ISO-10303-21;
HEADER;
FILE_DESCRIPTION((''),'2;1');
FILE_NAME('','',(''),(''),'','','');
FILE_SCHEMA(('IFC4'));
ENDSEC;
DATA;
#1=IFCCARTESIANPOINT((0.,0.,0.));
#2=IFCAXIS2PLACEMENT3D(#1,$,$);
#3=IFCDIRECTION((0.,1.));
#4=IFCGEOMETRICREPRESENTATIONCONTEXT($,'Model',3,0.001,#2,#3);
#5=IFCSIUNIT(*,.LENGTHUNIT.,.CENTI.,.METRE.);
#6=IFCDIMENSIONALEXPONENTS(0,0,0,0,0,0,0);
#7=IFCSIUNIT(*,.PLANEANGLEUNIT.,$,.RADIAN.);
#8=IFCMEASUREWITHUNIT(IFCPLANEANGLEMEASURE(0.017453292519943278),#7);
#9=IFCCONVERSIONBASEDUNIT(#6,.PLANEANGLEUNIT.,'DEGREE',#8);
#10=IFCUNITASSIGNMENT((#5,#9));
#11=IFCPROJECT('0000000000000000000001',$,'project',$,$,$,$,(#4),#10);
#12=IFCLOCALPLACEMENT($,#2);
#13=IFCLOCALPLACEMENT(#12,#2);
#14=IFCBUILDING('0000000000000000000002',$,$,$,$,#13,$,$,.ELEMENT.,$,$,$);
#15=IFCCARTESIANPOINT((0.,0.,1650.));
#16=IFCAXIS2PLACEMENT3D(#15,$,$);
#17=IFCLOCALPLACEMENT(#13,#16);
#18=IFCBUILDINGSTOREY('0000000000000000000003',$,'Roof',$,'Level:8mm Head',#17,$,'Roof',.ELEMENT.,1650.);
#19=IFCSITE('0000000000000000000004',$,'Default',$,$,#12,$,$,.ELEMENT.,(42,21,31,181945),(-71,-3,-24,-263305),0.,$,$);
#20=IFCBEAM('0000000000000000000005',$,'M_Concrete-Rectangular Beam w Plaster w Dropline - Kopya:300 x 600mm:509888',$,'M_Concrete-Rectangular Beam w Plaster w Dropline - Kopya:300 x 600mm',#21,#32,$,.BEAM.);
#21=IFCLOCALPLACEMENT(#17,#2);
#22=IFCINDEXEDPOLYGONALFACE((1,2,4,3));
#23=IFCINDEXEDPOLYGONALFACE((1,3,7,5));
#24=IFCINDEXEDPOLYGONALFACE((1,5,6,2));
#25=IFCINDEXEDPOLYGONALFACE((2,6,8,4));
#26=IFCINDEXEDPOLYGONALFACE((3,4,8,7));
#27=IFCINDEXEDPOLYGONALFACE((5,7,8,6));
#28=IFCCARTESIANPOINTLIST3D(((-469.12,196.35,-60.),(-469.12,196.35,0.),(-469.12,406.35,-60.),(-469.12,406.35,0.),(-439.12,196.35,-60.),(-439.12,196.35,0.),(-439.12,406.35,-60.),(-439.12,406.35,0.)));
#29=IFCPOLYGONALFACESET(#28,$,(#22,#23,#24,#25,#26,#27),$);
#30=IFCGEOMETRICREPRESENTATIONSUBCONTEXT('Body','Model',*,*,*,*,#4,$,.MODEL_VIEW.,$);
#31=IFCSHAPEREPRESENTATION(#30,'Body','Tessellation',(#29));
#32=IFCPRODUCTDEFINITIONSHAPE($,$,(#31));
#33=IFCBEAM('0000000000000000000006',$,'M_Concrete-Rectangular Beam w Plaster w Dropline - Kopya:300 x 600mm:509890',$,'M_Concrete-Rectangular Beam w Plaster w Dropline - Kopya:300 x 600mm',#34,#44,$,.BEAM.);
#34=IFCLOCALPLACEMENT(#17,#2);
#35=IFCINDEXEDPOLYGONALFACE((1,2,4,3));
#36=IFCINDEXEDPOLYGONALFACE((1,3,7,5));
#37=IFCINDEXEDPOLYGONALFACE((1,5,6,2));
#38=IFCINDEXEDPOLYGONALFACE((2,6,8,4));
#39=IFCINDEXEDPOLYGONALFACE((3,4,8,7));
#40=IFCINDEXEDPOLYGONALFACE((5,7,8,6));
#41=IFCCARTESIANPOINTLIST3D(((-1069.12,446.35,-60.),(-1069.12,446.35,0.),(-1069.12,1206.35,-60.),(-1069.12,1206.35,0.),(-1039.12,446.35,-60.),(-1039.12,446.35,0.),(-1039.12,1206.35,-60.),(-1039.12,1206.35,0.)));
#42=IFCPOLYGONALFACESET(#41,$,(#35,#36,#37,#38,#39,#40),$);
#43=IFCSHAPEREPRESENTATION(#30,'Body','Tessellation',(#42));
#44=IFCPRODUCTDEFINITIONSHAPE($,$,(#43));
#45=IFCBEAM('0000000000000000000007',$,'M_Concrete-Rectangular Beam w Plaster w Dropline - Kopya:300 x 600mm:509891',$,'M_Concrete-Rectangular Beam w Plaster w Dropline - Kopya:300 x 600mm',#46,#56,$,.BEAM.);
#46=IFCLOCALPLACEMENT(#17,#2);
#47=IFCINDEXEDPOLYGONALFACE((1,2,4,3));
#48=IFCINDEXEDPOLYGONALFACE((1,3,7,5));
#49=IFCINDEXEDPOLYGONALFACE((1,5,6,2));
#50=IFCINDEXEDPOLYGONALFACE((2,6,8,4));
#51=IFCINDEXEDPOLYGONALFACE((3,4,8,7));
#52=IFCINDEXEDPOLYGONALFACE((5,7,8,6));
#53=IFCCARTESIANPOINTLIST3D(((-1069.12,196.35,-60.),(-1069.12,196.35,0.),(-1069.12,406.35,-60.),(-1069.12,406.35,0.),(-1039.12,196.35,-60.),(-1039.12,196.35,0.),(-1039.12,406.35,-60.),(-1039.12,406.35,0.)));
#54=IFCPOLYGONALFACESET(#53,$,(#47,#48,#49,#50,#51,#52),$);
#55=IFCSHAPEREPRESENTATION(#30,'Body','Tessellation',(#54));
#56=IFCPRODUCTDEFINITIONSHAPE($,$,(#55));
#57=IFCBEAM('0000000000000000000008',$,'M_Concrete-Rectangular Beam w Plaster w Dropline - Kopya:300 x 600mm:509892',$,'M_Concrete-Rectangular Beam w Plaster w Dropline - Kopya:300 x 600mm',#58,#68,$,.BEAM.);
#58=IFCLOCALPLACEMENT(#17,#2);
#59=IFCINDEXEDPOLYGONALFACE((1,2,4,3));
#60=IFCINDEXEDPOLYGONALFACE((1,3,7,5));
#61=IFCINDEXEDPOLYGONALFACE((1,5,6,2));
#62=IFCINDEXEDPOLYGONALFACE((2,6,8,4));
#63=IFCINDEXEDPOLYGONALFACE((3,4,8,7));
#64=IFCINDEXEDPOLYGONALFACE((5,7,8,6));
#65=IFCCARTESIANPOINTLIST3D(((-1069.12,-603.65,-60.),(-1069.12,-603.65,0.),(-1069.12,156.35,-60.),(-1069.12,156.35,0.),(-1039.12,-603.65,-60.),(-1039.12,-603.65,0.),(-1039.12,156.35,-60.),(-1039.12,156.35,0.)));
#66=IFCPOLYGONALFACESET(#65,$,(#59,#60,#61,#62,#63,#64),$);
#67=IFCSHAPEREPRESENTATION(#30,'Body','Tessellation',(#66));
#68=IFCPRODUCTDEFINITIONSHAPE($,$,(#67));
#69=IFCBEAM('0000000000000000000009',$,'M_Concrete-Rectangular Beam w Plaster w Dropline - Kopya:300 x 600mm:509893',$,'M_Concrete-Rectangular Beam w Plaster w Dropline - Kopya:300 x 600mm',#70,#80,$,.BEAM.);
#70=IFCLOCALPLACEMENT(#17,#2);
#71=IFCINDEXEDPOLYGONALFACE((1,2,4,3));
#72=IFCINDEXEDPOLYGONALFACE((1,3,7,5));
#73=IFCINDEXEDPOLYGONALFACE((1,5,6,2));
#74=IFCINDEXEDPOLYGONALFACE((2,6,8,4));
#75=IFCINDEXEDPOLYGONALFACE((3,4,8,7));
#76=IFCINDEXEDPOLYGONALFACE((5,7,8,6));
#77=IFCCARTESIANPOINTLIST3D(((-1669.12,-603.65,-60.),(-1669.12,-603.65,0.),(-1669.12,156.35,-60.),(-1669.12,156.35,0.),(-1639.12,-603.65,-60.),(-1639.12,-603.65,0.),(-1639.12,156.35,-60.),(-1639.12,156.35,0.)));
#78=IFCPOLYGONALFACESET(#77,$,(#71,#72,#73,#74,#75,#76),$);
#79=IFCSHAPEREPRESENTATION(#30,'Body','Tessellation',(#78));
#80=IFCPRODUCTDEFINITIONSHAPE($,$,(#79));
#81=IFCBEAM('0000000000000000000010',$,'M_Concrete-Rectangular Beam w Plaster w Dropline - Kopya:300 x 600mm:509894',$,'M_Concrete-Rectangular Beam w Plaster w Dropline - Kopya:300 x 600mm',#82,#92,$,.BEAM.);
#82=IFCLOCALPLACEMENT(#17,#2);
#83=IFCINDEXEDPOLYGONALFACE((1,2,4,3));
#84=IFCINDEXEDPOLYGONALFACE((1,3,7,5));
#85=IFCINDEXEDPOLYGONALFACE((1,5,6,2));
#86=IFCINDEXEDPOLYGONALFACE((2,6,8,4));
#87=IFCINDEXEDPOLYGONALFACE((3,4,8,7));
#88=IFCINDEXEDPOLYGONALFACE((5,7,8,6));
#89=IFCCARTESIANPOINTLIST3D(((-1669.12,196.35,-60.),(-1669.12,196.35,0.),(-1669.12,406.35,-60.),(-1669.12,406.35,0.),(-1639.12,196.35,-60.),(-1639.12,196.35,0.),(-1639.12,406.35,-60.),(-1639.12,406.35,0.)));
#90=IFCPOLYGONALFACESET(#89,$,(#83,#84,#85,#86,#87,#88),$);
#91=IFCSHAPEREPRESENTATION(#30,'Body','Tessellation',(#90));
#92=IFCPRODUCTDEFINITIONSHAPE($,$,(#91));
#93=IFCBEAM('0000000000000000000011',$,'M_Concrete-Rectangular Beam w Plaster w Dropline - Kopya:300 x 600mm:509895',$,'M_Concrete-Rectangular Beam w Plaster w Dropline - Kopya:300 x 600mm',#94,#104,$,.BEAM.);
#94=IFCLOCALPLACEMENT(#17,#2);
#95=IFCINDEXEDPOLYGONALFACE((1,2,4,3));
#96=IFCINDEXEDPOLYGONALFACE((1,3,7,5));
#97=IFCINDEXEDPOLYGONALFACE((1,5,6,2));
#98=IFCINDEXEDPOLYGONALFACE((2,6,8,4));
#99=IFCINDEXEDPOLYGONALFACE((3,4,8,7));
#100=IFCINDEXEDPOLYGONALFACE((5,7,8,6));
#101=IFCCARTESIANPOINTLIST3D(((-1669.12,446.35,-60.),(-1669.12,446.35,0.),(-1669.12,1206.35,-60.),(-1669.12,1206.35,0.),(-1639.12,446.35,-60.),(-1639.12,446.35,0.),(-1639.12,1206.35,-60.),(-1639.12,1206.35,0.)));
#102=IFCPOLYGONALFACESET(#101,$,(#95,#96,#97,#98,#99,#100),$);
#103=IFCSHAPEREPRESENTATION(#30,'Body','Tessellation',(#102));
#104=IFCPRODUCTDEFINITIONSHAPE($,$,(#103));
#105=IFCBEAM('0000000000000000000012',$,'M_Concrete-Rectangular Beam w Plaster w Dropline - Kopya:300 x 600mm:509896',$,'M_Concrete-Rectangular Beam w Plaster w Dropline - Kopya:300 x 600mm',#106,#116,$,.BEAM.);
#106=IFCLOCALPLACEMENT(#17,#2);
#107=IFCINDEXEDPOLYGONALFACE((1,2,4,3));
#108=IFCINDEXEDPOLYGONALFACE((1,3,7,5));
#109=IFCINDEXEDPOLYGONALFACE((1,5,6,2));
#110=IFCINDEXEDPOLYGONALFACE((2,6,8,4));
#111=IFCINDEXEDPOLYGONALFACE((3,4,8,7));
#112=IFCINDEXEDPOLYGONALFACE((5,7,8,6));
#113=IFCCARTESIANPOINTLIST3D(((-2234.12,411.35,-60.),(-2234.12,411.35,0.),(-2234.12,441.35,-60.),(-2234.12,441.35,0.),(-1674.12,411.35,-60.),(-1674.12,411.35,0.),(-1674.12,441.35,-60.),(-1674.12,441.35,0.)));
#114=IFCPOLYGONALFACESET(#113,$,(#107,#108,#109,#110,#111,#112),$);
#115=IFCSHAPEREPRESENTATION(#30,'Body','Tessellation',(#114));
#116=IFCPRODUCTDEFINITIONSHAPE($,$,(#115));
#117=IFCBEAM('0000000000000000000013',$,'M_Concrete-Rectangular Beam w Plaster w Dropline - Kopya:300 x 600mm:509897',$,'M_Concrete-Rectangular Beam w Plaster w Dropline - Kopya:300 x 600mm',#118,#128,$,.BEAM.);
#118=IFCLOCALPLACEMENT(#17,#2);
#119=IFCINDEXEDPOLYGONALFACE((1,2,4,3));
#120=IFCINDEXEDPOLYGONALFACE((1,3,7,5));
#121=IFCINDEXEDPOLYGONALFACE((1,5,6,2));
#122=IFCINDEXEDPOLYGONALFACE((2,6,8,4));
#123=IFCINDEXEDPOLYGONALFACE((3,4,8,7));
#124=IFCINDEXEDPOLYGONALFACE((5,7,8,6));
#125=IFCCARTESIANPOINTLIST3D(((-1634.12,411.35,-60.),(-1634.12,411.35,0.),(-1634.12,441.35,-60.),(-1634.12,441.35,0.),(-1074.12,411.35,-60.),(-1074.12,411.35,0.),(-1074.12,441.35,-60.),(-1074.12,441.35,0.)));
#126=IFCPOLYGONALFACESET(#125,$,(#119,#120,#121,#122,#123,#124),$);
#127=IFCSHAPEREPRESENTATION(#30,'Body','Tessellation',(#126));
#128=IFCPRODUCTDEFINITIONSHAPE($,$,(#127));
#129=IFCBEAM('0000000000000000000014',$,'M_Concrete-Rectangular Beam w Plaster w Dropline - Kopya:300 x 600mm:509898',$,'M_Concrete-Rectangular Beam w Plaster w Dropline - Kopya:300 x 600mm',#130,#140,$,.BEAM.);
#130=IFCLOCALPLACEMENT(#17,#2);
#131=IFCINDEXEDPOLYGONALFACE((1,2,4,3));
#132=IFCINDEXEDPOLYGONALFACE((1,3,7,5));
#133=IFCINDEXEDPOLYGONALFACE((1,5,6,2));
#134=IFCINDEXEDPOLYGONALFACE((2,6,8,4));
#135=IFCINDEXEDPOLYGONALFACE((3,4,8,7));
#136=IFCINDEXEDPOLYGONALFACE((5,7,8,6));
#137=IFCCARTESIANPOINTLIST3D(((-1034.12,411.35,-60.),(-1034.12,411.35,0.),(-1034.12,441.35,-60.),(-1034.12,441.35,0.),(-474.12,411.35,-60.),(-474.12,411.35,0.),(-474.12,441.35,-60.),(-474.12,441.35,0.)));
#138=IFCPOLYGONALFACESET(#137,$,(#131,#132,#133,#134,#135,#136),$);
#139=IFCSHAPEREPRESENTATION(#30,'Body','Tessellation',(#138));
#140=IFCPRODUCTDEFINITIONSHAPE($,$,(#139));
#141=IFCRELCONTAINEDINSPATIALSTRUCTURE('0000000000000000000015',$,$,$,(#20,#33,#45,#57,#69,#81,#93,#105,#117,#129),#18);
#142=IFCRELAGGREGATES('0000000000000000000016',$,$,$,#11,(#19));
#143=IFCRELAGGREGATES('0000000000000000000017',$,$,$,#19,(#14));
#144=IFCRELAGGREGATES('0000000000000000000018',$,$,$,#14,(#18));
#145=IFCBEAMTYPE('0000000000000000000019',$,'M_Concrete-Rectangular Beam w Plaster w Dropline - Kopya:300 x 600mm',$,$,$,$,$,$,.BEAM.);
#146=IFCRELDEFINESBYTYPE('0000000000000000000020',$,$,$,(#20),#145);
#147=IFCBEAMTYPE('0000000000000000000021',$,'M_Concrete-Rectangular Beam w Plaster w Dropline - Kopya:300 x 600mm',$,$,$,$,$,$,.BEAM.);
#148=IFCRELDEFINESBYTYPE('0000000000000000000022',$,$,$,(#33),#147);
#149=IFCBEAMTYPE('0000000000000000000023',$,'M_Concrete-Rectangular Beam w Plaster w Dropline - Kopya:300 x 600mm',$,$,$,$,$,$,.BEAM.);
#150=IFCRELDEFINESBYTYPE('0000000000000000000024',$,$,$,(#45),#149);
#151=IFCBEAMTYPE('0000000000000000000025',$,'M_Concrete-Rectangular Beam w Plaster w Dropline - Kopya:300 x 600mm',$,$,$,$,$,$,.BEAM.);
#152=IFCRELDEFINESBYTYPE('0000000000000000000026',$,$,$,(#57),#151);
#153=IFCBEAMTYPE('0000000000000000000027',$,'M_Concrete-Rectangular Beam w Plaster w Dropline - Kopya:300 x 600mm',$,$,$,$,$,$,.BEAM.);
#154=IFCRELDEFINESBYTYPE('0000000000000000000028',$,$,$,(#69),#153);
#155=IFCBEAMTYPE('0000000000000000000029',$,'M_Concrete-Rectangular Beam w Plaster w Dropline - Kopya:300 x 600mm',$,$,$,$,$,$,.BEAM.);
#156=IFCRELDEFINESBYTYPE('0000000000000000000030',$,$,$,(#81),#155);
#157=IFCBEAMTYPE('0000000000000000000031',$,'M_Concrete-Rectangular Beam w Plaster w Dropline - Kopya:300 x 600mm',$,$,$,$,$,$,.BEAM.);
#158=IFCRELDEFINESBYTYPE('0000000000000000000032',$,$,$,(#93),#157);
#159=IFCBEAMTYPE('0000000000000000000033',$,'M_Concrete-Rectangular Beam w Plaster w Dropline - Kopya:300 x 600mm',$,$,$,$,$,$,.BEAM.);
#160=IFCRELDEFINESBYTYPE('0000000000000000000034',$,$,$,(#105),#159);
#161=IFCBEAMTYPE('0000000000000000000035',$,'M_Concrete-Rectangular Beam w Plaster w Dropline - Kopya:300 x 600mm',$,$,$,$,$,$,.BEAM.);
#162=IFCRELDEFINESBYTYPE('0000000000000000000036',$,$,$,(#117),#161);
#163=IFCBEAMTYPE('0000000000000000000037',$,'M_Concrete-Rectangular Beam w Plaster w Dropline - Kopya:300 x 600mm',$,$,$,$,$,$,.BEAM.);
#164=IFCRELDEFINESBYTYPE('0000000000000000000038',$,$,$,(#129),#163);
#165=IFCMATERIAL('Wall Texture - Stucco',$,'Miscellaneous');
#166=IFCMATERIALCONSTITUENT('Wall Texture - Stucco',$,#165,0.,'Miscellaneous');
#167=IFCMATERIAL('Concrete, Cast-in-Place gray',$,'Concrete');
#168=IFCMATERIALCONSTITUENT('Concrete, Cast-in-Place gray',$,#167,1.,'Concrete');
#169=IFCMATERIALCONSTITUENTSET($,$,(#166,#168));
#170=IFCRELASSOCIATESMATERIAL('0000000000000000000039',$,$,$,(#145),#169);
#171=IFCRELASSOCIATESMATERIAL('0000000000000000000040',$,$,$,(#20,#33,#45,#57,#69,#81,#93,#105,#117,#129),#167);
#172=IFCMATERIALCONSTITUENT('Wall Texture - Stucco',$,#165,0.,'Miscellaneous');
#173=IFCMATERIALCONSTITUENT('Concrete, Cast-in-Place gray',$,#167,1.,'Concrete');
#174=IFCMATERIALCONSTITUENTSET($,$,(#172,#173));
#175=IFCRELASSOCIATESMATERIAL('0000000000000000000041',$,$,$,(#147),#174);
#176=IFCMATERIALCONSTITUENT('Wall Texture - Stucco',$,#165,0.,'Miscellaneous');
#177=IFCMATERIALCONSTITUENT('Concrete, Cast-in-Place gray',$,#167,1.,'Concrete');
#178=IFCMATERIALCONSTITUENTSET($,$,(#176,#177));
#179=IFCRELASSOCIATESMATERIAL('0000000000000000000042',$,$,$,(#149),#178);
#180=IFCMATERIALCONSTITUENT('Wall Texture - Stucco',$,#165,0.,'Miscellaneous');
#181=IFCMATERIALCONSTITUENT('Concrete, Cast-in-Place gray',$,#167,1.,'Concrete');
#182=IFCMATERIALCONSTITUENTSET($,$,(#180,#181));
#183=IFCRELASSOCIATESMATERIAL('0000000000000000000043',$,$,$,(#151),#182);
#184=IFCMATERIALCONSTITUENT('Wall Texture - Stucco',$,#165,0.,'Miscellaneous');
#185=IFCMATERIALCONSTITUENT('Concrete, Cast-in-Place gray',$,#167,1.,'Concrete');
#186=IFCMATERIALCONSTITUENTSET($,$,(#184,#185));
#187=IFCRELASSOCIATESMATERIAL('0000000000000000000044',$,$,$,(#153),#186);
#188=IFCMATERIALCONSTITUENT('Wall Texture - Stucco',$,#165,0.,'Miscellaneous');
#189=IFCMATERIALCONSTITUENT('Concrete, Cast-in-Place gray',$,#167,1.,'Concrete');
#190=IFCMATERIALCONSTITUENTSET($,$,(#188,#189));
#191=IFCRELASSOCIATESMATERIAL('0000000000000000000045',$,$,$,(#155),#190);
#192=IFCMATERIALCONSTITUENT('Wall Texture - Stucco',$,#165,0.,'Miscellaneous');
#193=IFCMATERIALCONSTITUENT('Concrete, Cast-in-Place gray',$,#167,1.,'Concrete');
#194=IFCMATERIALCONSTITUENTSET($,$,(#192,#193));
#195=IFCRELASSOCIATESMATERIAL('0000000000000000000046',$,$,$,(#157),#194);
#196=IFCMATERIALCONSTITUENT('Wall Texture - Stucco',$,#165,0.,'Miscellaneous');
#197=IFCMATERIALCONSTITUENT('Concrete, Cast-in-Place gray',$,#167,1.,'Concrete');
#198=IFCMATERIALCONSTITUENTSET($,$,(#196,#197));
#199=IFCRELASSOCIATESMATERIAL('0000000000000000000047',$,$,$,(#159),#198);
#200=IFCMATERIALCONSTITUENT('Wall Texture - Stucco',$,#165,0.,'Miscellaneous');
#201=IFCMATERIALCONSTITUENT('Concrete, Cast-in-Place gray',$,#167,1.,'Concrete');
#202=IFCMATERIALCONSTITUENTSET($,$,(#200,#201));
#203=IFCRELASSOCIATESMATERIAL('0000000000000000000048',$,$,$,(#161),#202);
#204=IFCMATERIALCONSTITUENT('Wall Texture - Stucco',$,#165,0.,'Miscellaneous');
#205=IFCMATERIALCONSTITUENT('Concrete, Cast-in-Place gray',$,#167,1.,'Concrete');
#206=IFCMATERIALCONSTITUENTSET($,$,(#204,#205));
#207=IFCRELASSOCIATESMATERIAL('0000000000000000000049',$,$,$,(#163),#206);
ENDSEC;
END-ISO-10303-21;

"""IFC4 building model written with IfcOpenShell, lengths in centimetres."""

from ifc_helpers import new_model, entity, si_unit, converted_unit, direction, frame, origin, place, context, subcontext, project, spatial, indexed_curve, outline, extrude, source, transform, mapped, material, constituent, constituent_set, type_object, type_shapes, element, save


model = new_model("IFC4")

# Units and contexts
model_context = context("Model", 3, precision=0.001, world=origin(), true_north=direction((0.0, 1.0)))
body_context = subcontext(model_context, "Body", "Model", "MODEL_VIEW")
ifc_project = project(units=[si_unit("LENGTHUNIT", "METRE", prefix="CENTI"), converted_unit("PLANEANGLEUNIT", "DEGREE", entity("IfcPlaneAngleMeasure", 0.017453292519943278), si_unit("PLANEANGLEUNIT", "RADIAN"), dimensions=[0, 0, 0, 0, 0, 0, 0])], contexts=[model_context])

# Site, building, storey
site_placement = place(None, origin())
site = spatial("IfcSite", under=ifc_project, at=site_placement, Name="Default", CompositionType="ELEMENT", RefLatitude=(42, 21, 31, 181945), RefLongitude=(-71, -3, -24, -263305), RefElevation=0.0)
building_placement = place(site_placement, origin())
building = spatial("IfcBuilding", under=site, at=building_placement, CompositionType="ELEMENT")
storey_placement = place(building_placement, frame((0.0, 0.0, 1650.0)))
storey = spatial("IfcBuildingStorey", under=building, at=storey_placement, Name="Roof", ObjectType="Level:8mm Head", LongName="Roof", CompositionType="ELEMENT", Elevation=1650.0)

# Beams
ifc_material_1 = material(Name="Concrete, Cast-in-Place gray", Category="Concrete")
ifc_material_2 = material(Name="Wall Texture - Stucco", Category="Miscellaneous")
ifc_constituent_1 = constituent(ifc_material_2, Name="Wall Texture - Stucco", Category="Miscellaneous", fraction=0.0)
ifc_constituent_2 = constituent(ifc_material_1, Name="Concrete, Cast-in-Place gray", Category="Concrete", fraction=1.0)
ifc_constituent_set_1 = constituent_set(constituents=[ifc_constituent_1, ifc_constituent_2])
beam_type_1 = type_object("IfcBeamType", Name="M_Concrete-Rectangular Beam w Plaster w Dropline - Kopya:300 x 600mm", PredefinedType="BEAM", material=ifc_constituent_set_1)
shared_shape_1 = source(origin(), body_context, "Body", "SweptSolid", [
    extrude(outline(indexed_curve([(-15.0, -30.0), (15.0, -30.0), (15.0, 30.0), (-15.0, 30.0), (-15.0, -30.0)], self_intersect=False)), frame((-454.12, 196.35, 1620.0), z_axis=(0.0, 1.0, 0.0), x_axis=(-1.0, 0.0, 0.0)), (0.0, 0.0, 1.0), 210.0),
])
type_shapes(beam_type_1, [shared_shape_1])
beam_1_placement = place(storey_placement, frame((0.0, 0.0, -1650.0)))
element("IfcBeam", 1, at=beam_1_placement, inside=storey, type_object=beam_type_1, material=ifc_material_1, Name="M_Concrete-Rectangular Beam w Plaster w Dropline - Kopya:300 x 600mm:509888", ObjectType="M_Concrete-Rectangular Beam w Plaster w Dropline - Kopya:300 x 600mm", PredefinedType="BEAM", context=body_context, shape_type="MappedRepresentation", body=[
    mapped(shared_shape_1, transform((0.0, 0.0, 0.0), scale=1.0)),
])
ifc_constituent_3 = constituent(ifc_material_2, Name="Wall Texture - Stucco", Category="Miscellaneous", fraction=0.0)
ifc_constituent_4 = constituent(ifc_material_1, Name="Concrete, Cast-in-Place gray", Category="Concrete", fraction=1.0)
ifc_constituent_set_2 = constituent_set(constituents=[ifc_constituent_3, ifc_constituent_4])
beam_type_2 = type_object("IfcBeamType", Name="M_Concrete-Rectangular Beam w Plaster w Dropline - Kopya:300 x 600mm", PredefinedType="BEAM", material=ifc_constituent_set_2)
shared_shape_2 = source(origin(), body_context, "Body", "SweptSolid", [
    extrude(outline(indexed_curve([(-15.0, -30.0), (15.0, -30.0), (15.0, 30.0), (-15.0, 30.0), (-15.0, -30.0)], self_intersect=False)), frame((-1054.12, 1206.35, 1620.0), z_axis=(0.0, -1.0, 0.0), x_axis=(-1.0, 0.0, 0.0)), (0.0, 0.0, 1.0), 760.0),
])
type_shapes(beam_type_2, [shared_shape_2])
beam_2_placement = place(storey_placement, frame((0.0, 0.0, -1650.0)))
element("IfcBeam", 2, at=beam_2_placement, inside=storey, type_object=beam_type_2, material=ifc_material_1, Name="M_Concrete-Rectangular Beam w Plaster w Dropline - Kopya:300 x 600mm:509890", ObjectType="M_Concrete-Rectangular Beam w Plaster w Dropline - Kopya:300 x 600mm", PredefinedType="BEAM", context=body_context, shape_type="MappedRepresentation", body=[
    mapped(shared_shape_2, transform((0.0, 0.0, 0.0), scale=1.0)),
])
ifc_constituent_5 = constituent(ifc_material_2, Name="Wall Texture - Stucco", Category="Miscellaneous", fraction=0.0)
ifc_constituent_6 = constituent(ifc_material_1, Name="Concrete, Cast-in-Place gray", Category="Concrete", fraction=1.0)
ifc_constituent_set_3 = constituent_set(constituents=[ifc_constituent_5, ifc_constituent_6])
beam_type_3 = type_object("IfcBeamType", Name="M_Concrete-Rectangular Beam w Plaster w Dropline - Kopya:300 x 600mm", PredefinedType="BEAM", material=ifc_constituent_set_3)
shared_shape_3 = source(origin(), body_context, "Body", "SweptSolid", [
    extrude(outline(indexed_curve([(-15.0, -30.0), (15.0, -30.0), (15.0, 30.0), (-15.0, 30.0), (-15.0, -30.0)], self_intersect=False)), frame((-1054.12, 406.35, 1620.0), z_axis=(0.0, -1.0, 0.0), x_axis=(-1.0, 0.0, 0.0)), (0.0, 0.0, 1.0), 210.0),
])
type_shapes(beam_type_3, [shared_shape_3])
beam_3_placement = place(storey_placement, frame((0.0, 0.0, -1650.0)))
element("IfcBeam", 3, at=beam_3_placement, inside=storey, type_object=beam_type_3, material=ifc_material_1, Name="M_Concrete-Rectangular Beam w Plaster w Dropline - Kopya:300 x 600mm:509891", ObjectType="M_Concrete-Rectangular Beam w Plaster w Dropline - Kopya:300 x 600mm", PredefinedType="BEAM", context=body_context, shape_type="MappedRepresentation", body=[
    mapped(shared_shape_3, transform((0.0, 0.0, 0.0), scale=1.0)),
])
ifc_constituent_7 = constituent(ifc_material_2, Name="Wall Texture - Stucco", Category="Miscellaneous", fraction=0.0)
ifc_constituent_8 = constituent(ifc_material_1, Name="Concrete, Cast-in-Place gray", Category="Concrete", fraction=1.0)
ifc_constituent_set_4 = constituent_set(constituents=[ifc_constituent_7, ifc_constituent_8])
beam_type_4 = type_object("IfcBeamType", Name="M_Concrete-Rectangular Beam w Plaster w Dropline - Kopya:300 x 600mm", PredefinedType="BEAM", material=ifc_constituent_set_4)
shared_shape_4 = source(origin(), body_context, "Body", "SweptSolid", [
    extrude(outline(indexed_curve([(-15.0, -30.0), (15.0, -30.0), (15.0, 30.0), (-15.0, 30.0), (-15.0, -30.0)], self_intersect=False)), frame((-1054.12, 156.35, 1620.0), z_axis=(0.0, -1.0, 0.0), x_axis=(-1.0, 0.0, 0.0)), (0.0, 0.0, 1.0), 760.0),
])
type_shapes(beam_type_4, [shared_shape_4])
beam_4_placement = place(storey_placement, frame((0.0, 0.0, -1650.0)))
element("IfcBeam", 4, at=beam_4_placement, inside=storey, type_object=beam_type_4, material=ifc_material_1, Name="M_Concrete-Rectangular Beam w Plaster w Dropline - Kopya:300 x 600mm:509892", ObjectType="M_Concrete-Rectangular Beam w Plaster w Dropline - Kopya:300 x 600mm", PredefinedType="BEAM", context=body_context, shape_type="MappedRepresentation", body=[
    mapped(shared_shape_4, transform((0.0, 0.0, 0.0), scale=1.0)),
])
ifc_constituent_9 = constituent(ifc_material_2, Name="Wall Texture - Stucco", Category="Miscellaneous", fraction=0.0)
ifc_constituent_10 = constituent(ifc_material_1, Name="Concrete, Cast-in-Place gray", Category="Concrete", fraction=1.0)
ifc_constituent_set_5 = constituent_set(constituents=[ifc_constituent_9, ifc_constituent_10])
beam_type_5 = type_object("IfcBeamType", Name="M_Concrete-Rectangular Beam w Plaster w Dropline - Kopya:300 x 600mm", PredefinedType="BEAM", material=ifc_constituent_set_5)
shared_shape_5 = source(origin(), body_context, "Body", "SweptSolid", [
    extrude(outline(indexed_curve([(-15.0, -30.0), (15.0, -30.0), (15.0, 30.0), (-15.0, 30.0), (-15.0, -30.0)], self_intersect=False)), frame((-1654.12, -603.65, 1620.0), z_axis=(0.0, 1.0, 0.0), x_axis=(-1.0, 0.0, 0.0)), (0.0, 0.0, 1.0), 760.0),
])
type_shapes(beam_type_5, [shared_shape_5])
beam_5_placement = place(storey_placement, frame((0.0, 0.0, -1650.0)))
element("IfcBeam", 5, at=beam_5_placement, inside=storey, type_object=beam_type_5, material=ifc_material_1, Name="M_Concrete-Rectangular Beam w Plaster w Dropline - Kopya:300 x 600mm:509893", ObjectType="M_Concrete-Rectangular Beam w Plaster w Dropline - Kopya:300 x 600mm", PredefinedType="BEAM", context=body_context, shape_type="MappedRepresentation", body=[
    mapped(shared_shape_5, transform((0.0, 0.0, 0.0), scale=1.0)),
])
ifc_constituent_11 = constituent(ifc_material_2, Name="Wall Texture - Stucco", Category="Miscellaneous", fraction=0.0)
ifc_constituent_12 = constituent(ifc_material_1, Name="Concrete, Cast-in-Place gray", Category="Concrete", fraction=1.0)
ifc_constituent_set_6 = constituent_set(constituents=[ifc_constituent_11, ifc_constituent_12])
beam_type_6 = type_object("IfcBeamType", Name="M_Concrete-Rectangular Beam w Plaster w Dropline - Kopya:300 x 600mm", PredefinedType="BEAM", material=ifc_constituent_set_6)
shared_shape_6 = source(origin(), body_context, "Body", "SweptSolid", [
    extrude(outline(indexed_curve([(-15.0, -30.0), (15.0, -30.0), (15.0, 30.0), (-15.0, 30.0), (-15.0, -30.0)], self_intersect=False)), frame((-1654.12, 196.35, 1620.0), z_axis=(0.0, 1.0, 0.0), x_axis=(-1.0, 0.0, 0.0)), (0.0, 0.0, 1.0), 210.0),
])
type_shapes(beam_type_6, [shared_shape_6])
beam_6_placement = place(storey_placement, frame((0.0, 0.0, -1650.0)))
element("IfcBeam", 6, at=beam_6_placement, inside=storey, type_object=beam_type_6, material=ifc_material_1, Name="M_Concrete-Rectangular Beam w Plaster w Dropline - Kopya:300 x 600mm:509894", ObjectType="M_Concrete-Rectangular Beam w Plaster w Dropline - Kopya:300 x 600mm", PredefinedType="BEAM", context=body_context, shape_type="MappedRepresentation", body=[
    mapped(shared_shape_6, transform((0.0, 0.0, 0.0), scale=1.0)),
])
ifc_constituent_13 = constituent(ifc_material_2, Name="Wall Texture - Stucco", Category="Miscellaneous", fraction=0.0)
ifc_constituent_14 = constituent(ifc_material_1, Name="Concrete, Cast-in-Place gray", Category="Concrete", fraction=1.0)
ifc_constituent_set_7 = constituent_set(constituents=[ifc_constituent_13, ifc_constituent_14])
beam_type_7 = type_object("IfcBeamType", Name="M_Concrete-Rectangular Beam w Plaster w Dropline - Kopya:300 x 600mm", PredefinedType="BEAM", material=ifc_constituent_set_7)
shared_shape_7 = source(origin(), body_context, "Body", "SweptSolid", [
    extrude(outline(indexed_curve([(-15.0, -30.0), (15.0, -30.0), (15.0, 30.0), (-15.0, 30.0), (-15.0, -30.0)], self_intersect=False)), frame((-1654.12, 446.35, 1620.0), z_axis=(0.0, 1.0, 0.0), x_axis=(-1.0, 0.0, 0.0)), (0.0, 0.0, 1.0), 760.0),
])
type_shapes(beam_type_7, [shared_shape_7])
beam_7_placement = place(storey_placement, frame((0.0, 0.0, -1650.0)))
element("IfcBeam", 7, at=beam_7_placement, inside=storey, type_object=beam_type_7, material=ifc_material_1, Name="M_Concrete-Rectangular Beam w Plaster w Dropline - Kopya:300 x 600mm:509895", ObjectType="M_Concrete-Rectangular Beam w Plaster w Dropline - Kopya:300 x 600mm", PredefinedType="BEAM", context=body_context, shape_type="MappedRepresentation", body=[
    mapped(shared_shape_7, transform((0.0, 0.0, 0.0), scale=1.0)),
])
ifc_constituent_15 = constituent(ifc_material_2, Name="Wall Texture - Stucco", Category="Miscellaneous", fraction=0.0)
ifc_constituent_16 = constituent(ifc_material_1, Name="Concrete, Cast-in-Place gray", Category="Concrete", fraction=1.0)
ifc_constituent_set_8 = constituent_set(constituents=[ifc_constituent_15, ifc_constituent_16])
beam_type_8 = type_object("IfcBeamType", Name="M_Concrete-Rectangular Beam w Plaster w Dropline - Kopya:300 x 600mm", PredefinedType="BEAM", material=ifc_constituent_set_8)
shared_shape_8 = source(origin(), body_context, "Body", "SweptSolid", [
    extrude(outline(indexed_curve([(-30.0, -15.0), (30.0, -15.0), (30.0, 15.0), (-30.0, 15.0), (-30.0, -15.0)], self_intersect=False)), frame((-2234.12, 426.35, 1620.0), z_axis=(1.0, 0.0, 0.0), x_axis=(0.0, 0.0, -1.0)), (0.0, 0.0, 1.0), 560.0),
])
type_shapes(beam_type_8, [shared_shape_8])
beam_8_placement = place(storey_placement, frame((0.0, 0.0, -1650.0)))
element("IfcBeam", 8, at=beam_8_placement, inside=storey, type_object=beam_type_8, material=ifc_material_1, Name="M_Concrete-Rectangular Beam w Plaster w Dropline - Kopya:300 x 600mm:509896", ObjectType="M_Concrete-Rectangular Beam w Plaster w Dropline - Kopya:300 x 600mm", PredefinedType="BEAM", context=body_context, shape_type="MappedRepresentation", body=[
    mapped(shared_shape_8, transform((0.0, 0.0, 0.0), scale=1.0)),
])
ifc_constituent_17 = constituent(ifc_material_2, Name="Wall Texture - Stucco", Category="Miscellaneous", fraction=0.0)
ifc_constituent_18 = constituent(ifc_material_1, Name="Concrete, Cast-in-Place gray", Category="Concrete", fraction=1.0)
ifc_constituent_set_9 = constituent_set(constituents=[ifc_constituent_17, ifc_constituent_18])
beam_type_9 = type_object("IfcBeamType", Name="M_Concrete-Rectangular Beam w Plaster w Dropline - Kopya:300 x 600mm", PredefinedType="BEAM", material=ifc_constituent_set_9)
shared_shape_9 = source(origin(), body_context, "Body", "SweptSolid", [
    extrude(outline(indexed_curve([(-30.0, -15.0), (30.0, -15.0), (30.0, 15.0), (-30.0, 15.0), (-30.0, -15.0)], self_intersect=False)), frame((-1634.12, 426.35, 1620.0), z_axis=(1.0, 0.0, 0.0), x_axis=(0.0, 0.0, -1.0)), (0.0, 0.0, 1.0), 560.0),
])
type_shapes(beam_type_9, [shared_shape_9])
beam_9_placement = place(storey_placement, frame((0.0, 0.0, -1650.0)))
element("IfcBeam", 9, at=beam_9_placement, inside=storey, type_object=beam_type_9, material=ifc_material_1, Name="M_Concrete-Rectangular Beam w Plaster w Dropline - Kopya:300 x 600mm:509897", ObjectType="M_Concrete-Rectangular Beam w Plaster w Dropline - Kopya:300 x 600mm", PredefinedType="BEAM", context=body_context, shape_type="MappedRepresentation", body=[
    mapped(shared_shape_9, transform((0.0, 0.0, 0.0), scale=1.0)),
])
ifc_constituent_19 = constituent(ifc_material_2, Name="Wall Texture - Stucco", Category="Miscellaneous", fraction=0.0)
ifc_constituent_20 = constituent(ifc_material_1, Name="Concrete, Cast-in-Place gray", Category="Concrete", fraction=1.0)
ifc_constituent_set_10 = constituent_set(constituents=[ifc_constituent_19, ifc_constituent_20])
beam_type_10 = type_object("IfcBeamType", Name="M_Concrete-Rectangular Beam w Plaster w Dropline - Kopya:300 x 600mm", PredefinedType="BEAM", material=ifc_constituent_set_10)
shared_shape_10 = source(origin(), body_context, "Body", "SweptSolid", [
    extrude(outline(indexed_curve([(-30.0, -15.0), (30.0, -15.0), (30.0, 15.0), (-30.0, 15.0), (-30.0, -15.0)], self_intersect=False)), frame((-1034.12, 426.35, 1620.0), z_axis=(1.0, 0.0, 0.0), x_axis=(0.0, 0.0, -1.0)), (0.0, 0.0, 1.0), 560.0),
])
type_shapes(beam_type_10, [shared_shape_10])
beam_10_placement = place(storey_placement, frame((0.0, 0.0, -1650.0)))
element("IfcBeam", 10, at=beam_10_placement, inside=storey, type_object=beam_type_10, material=ifc_material_1, Name="M_Concrete-Rectangular Beam w Plaster w Dropline - Kopya:300 x 600mm:509898", ObjectType="M_Concrete-Rectangular Beam w Plaster w Dropline - Kopya:300 x 600mm", PredefinedType="BEAM", context=body_context, shape_type="MappedRepresentation", body=[
    mapped(shared_shape_10, transform((0.0, 0.0, 0.0), scale=1.0)),
])

save(model, "model.ifc")
